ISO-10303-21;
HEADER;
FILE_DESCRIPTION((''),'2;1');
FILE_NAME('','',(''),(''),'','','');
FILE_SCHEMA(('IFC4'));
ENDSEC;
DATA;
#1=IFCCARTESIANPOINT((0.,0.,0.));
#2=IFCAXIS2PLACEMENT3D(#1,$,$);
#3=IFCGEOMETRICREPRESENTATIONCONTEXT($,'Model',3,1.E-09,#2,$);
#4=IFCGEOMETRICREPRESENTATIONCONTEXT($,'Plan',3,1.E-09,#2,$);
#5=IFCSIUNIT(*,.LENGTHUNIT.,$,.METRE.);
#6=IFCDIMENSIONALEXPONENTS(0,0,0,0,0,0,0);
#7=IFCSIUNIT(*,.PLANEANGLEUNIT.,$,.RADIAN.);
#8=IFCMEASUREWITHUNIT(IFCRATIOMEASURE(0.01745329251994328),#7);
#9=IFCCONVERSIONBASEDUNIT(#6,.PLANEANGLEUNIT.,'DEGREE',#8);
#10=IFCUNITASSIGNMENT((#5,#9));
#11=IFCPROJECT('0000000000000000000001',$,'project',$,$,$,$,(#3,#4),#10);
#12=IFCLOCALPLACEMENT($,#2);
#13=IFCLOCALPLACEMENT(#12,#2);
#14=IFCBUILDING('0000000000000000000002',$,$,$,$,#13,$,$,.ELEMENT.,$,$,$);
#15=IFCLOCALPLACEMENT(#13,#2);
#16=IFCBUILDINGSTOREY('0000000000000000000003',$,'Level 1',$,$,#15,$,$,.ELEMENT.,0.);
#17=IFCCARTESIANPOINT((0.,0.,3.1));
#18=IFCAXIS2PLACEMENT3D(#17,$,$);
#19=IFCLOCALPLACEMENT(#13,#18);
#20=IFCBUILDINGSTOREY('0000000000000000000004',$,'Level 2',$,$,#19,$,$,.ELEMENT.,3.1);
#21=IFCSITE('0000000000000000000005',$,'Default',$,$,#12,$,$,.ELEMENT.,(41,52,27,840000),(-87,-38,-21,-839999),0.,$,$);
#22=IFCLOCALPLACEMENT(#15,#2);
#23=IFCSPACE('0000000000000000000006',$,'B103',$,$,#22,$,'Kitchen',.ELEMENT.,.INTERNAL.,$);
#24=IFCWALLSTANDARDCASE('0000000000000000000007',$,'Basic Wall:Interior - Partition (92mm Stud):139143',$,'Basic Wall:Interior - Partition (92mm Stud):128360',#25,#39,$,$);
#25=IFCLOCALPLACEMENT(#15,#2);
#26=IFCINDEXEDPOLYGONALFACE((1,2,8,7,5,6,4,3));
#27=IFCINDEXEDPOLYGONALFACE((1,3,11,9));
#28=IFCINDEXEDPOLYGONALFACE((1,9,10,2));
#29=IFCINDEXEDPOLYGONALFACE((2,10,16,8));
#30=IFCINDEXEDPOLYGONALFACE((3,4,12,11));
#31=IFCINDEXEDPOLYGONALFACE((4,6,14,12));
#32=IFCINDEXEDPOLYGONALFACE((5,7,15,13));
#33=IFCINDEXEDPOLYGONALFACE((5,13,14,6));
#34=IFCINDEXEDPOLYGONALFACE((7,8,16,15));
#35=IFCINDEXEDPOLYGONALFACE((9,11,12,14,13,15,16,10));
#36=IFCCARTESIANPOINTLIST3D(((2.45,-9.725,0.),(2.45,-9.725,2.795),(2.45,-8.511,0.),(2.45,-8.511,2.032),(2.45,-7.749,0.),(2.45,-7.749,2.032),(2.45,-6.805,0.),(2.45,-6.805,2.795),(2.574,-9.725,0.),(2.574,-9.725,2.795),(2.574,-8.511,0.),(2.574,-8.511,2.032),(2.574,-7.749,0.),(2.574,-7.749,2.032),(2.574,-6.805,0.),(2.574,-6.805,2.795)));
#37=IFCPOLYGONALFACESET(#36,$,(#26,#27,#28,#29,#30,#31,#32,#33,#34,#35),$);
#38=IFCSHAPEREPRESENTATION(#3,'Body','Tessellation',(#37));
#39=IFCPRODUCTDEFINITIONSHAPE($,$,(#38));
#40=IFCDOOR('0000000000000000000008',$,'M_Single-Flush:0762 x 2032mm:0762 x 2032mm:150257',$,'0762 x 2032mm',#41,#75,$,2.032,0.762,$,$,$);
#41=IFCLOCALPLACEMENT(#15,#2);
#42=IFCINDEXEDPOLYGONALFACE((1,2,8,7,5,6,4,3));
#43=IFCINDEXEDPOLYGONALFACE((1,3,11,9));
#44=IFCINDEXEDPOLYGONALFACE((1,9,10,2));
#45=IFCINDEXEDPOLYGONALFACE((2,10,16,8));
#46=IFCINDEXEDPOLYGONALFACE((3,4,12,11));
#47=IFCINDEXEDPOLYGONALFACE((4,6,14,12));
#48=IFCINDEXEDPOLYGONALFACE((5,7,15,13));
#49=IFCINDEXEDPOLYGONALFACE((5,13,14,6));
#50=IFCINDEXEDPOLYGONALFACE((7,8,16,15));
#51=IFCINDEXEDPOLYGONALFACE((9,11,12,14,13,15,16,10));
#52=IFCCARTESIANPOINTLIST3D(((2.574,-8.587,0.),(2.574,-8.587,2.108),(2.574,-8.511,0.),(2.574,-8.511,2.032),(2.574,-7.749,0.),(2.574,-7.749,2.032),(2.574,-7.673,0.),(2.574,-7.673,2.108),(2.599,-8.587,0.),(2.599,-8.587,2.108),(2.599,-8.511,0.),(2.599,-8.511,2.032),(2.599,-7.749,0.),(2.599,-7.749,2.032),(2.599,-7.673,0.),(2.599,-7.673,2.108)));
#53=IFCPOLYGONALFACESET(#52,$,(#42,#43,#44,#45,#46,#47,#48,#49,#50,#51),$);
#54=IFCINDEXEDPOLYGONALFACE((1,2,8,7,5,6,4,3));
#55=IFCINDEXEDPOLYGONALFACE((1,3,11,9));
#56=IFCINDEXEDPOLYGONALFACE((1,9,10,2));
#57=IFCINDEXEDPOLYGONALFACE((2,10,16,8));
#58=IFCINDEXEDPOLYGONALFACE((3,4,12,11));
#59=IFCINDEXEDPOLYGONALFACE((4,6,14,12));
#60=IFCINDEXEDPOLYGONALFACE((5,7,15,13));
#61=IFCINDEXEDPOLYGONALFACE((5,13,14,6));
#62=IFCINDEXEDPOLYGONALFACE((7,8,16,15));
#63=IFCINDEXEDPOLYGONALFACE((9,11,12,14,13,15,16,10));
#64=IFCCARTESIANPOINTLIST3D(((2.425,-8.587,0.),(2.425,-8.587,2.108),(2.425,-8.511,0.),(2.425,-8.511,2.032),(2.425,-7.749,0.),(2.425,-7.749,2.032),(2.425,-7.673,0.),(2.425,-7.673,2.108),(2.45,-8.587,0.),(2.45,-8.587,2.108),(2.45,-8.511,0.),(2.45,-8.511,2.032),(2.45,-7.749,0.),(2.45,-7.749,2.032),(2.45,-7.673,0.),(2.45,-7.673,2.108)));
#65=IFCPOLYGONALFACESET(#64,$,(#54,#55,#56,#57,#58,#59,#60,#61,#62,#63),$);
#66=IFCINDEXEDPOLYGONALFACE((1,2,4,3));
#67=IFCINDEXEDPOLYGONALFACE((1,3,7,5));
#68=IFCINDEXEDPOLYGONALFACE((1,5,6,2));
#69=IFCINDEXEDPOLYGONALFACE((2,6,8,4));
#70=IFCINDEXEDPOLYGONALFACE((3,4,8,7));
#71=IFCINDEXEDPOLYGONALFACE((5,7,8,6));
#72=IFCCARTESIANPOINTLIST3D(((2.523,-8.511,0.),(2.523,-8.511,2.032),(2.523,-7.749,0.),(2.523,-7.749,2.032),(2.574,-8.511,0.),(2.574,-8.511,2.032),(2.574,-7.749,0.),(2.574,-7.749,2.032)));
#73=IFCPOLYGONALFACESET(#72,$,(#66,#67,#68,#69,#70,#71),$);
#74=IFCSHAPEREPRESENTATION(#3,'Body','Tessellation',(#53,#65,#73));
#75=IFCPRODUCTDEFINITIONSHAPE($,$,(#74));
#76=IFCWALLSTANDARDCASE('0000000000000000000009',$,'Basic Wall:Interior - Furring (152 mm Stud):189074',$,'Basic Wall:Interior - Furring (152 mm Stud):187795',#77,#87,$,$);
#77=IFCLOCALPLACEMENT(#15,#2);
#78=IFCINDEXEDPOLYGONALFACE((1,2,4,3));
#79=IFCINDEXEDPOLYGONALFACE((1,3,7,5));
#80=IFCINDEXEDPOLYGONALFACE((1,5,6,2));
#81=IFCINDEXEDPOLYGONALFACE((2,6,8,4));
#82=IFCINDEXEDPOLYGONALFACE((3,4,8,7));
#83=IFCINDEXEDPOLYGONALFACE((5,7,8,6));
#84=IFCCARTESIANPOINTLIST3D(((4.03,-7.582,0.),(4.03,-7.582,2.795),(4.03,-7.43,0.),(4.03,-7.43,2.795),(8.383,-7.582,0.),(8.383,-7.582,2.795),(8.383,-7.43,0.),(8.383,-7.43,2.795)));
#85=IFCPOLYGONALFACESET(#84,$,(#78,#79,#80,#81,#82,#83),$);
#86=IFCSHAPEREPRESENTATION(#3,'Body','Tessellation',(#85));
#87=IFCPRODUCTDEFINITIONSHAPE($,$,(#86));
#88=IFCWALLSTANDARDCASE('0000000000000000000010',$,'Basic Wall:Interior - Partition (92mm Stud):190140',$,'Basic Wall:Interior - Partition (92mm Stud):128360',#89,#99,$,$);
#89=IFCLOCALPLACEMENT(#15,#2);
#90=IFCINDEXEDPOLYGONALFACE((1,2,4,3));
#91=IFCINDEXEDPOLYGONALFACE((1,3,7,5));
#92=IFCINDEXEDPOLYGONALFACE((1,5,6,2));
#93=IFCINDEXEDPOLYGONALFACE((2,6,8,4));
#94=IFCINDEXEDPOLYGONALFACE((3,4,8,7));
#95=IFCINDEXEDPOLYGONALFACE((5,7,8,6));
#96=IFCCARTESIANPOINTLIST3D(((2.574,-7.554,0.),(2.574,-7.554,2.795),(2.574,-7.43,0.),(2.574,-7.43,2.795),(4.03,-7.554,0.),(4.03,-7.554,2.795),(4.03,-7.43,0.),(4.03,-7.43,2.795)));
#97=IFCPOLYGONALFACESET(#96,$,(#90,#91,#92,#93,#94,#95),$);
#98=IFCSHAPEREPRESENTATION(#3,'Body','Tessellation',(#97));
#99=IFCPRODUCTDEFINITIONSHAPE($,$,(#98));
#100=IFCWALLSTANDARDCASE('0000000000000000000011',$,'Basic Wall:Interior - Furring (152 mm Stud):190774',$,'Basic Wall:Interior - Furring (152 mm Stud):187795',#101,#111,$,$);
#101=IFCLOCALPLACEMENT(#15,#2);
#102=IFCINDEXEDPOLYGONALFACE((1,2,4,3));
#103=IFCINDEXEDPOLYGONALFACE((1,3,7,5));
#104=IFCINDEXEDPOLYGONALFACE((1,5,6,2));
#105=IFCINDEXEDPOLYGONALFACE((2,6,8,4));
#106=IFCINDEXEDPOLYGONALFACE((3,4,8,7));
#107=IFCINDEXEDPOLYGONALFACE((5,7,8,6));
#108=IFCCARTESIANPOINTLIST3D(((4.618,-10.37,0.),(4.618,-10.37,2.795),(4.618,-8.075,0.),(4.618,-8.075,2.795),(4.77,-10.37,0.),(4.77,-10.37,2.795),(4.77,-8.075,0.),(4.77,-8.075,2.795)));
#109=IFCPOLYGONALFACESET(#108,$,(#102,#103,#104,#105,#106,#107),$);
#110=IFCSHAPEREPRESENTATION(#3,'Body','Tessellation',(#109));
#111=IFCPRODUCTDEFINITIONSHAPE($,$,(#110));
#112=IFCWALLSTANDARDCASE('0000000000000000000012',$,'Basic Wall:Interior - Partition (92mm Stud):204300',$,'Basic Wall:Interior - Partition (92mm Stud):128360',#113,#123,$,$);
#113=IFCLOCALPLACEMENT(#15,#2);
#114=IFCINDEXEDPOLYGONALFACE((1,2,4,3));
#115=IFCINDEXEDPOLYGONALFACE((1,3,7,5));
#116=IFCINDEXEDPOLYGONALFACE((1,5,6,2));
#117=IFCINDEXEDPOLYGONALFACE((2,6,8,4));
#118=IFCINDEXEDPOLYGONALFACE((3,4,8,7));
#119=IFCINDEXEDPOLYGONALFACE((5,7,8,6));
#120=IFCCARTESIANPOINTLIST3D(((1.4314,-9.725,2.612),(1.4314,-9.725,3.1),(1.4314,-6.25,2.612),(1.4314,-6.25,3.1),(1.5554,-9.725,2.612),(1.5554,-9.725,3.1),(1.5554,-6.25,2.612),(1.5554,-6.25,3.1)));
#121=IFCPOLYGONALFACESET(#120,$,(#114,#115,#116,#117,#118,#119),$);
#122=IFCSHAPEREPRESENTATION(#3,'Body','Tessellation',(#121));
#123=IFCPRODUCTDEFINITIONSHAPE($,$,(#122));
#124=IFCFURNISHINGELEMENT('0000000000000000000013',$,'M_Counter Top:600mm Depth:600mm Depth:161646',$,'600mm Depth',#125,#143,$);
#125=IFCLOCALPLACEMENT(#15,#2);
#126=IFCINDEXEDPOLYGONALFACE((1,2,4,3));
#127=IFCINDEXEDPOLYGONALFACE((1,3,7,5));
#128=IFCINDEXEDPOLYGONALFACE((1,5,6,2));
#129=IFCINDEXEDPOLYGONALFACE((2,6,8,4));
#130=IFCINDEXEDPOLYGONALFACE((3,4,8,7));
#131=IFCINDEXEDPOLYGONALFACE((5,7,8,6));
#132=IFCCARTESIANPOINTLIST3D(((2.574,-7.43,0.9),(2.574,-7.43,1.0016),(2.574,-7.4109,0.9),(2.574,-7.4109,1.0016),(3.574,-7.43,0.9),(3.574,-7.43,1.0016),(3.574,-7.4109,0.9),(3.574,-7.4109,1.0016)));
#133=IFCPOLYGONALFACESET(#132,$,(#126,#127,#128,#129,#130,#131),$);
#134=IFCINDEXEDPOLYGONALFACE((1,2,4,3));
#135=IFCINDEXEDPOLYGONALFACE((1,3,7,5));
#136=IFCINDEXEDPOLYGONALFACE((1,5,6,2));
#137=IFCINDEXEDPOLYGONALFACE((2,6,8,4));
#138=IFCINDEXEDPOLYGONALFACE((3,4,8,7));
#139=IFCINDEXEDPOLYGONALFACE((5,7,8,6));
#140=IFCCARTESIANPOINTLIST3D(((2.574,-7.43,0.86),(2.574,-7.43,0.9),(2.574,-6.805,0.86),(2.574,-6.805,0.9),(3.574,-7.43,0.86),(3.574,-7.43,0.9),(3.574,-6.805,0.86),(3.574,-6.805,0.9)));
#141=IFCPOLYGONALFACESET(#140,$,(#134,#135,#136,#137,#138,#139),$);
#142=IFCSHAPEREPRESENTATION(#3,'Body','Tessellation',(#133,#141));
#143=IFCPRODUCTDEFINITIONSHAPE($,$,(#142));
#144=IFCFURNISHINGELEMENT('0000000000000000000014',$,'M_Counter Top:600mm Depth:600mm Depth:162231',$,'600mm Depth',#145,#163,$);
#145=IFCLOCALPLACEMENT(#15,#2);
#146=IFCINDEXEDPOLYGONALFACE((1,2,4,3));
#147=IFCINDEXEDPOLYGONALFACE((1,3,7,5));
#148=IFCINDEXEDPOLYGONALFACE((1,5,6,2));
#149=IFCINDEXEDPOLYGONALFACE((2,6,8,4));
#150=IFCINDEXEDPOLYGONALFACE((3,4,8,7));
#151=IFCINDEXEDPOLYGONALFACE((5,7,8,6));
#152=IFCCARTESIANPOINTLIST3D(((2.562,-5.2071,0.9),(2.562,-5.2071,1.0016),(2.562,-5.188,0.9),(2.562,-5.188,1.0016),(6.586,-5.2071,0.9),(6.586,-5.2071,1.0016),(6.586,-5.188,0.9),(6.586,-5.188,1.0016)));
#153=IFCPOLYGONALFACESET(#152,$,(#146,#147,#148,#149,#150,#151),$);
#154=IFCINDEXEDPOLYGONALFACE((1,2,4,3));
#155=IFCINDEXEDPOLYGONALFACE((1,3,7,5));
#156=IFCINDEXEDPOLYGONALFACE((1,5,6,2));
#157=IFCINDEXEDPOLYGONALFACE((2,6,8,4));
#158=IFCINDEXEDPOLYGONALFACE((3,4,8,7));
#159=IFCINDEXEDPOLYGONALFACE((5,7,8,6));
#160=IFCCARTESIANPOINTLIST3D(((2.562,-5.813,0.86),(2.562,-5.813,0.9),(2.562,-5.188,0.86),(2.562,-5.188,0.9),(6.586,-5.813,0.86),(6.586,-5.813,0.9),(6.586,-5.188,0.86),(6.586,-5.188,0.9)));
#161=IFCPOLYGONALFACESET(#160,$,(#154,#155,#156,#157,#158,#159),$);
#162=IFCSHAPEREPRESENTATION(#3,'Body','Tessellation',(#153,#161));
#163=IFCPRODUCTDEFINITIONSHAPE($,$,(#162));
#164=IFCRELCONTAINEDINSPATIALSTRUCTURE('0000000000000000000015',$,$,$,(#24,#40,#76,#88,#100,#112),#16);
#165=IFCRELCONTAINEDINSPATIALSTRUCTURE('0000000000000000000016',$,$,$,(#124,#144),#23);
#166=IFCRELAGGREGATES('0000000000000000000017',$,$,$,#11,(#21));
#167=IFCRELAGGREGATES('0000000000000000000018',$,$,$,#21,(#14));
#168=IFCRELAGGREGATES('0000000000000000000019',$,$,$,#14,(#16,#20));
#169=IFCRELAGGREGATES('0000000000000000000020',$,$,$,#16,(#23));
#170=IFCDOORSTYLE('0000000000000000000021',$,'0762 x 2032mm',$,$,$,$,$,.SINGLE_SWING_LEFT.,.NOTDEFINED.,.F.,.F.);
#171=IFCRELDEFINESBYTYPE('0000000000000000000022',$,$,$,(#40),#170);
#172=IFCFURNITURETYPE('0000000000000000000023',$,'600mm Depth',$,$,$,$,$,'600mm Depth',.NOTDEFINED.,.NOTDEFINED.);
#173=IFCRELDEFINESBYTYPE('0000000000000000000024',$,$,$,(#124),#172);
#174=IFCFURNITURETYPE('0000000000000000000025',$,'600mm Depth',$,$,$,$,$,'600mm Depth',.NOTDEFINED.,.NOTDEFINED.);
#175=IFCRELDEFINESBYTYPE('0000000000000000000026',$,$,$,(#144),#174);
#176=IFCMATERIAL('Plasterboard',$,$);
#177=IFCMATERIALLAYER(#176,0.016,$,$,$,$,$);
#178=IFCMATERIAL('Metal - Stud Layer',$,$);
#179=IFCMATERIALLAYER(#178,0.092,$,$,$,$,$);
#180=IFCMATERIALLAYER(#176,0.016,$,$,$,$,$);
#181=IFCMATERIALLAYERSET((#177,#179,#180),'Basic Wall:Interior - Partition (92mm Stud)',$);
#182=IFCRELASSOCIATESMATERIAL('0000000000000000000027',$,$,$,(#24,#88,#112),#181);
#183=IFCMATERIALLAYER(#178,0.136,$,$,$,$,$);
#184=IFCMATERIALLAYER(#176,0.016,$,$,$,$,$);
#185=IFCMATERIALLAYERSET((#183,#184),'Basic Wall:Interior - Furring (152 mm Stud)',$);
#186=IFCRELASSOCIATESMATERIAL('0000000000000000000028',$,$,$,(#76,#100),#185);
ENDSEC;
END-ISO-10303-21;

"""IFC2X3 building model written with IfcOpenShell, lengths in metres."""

from ifc_helpers import new_model, entity, si_unit, converted_unit, frame, frame_2d, origin, origin_2d_with_axis, place, context, project, spatial, polyline, rectangle, outline, extrude, clip, bounded_halfspace, source, transform, mapped, material, layer, layer_set, layer_usage, type_object, type_shapes, element, fill, save


model = new_model("IFC2X3")

# Units and contexts
model_context = context("Model", 3, precision=1e-09, world=origin())
plan_context = context("Plan", 3, precision=1e-09, world=origin())
ifc_project = project(units=[si_unit("LENGTHUNIT", "METRE"), converted_unit("PLANEANGLEUNIT", "DEGREE", entity("IfcRatioMeasure", 0.01745329251994328), si_unit("PLANEANGLEUNIT", "RADIAN"), dimensions=[0, 0, 0, 0, 0, 0, 0])], contexts=[model_context, plan_context])

# Site, building, storey
site_placement = place(None, origin())
site = spatial("IfcSite", under=ifc_project, at=site_placement, Name="Default", CompositionType="ELEMENT", RefLatitude=(41, 52, 27, 840000), RefLongitude=(-87, -38, -21, -839999), RefElevation=0.0)
building_placement = place(site_placement, origin())
building = spatial("IfcBuilding", under=site, at=building_placement, CompositionType="ELEMENT")
storey_1_placement = place(building_placement, origin())
storey_1 = spatial("IfcBuildingStorey", under=building, at=storey_1_placement, Name="Level 1", CompositionType="ELEMENT", Elevation=0.0)

# Shared definitions
ifc_material_1 = material(Name="Metal - Stud Layer")
ifc_material_2 = material(Name="Plasterboard")

# Wall, opening, door
ifc_layer_1 = layer(ifc_material_2, 0.016)
ifc_layer_2 = layer(ifc_material_1, 0.092)
ifc_layer_3 = layer(ifc_material_2, 0.016)
ifc_layer_set_1 = layer_set([ifc_layer_1, ifc_layer_2, ifc_layer_3], Name="Basic Wall:Interior - Partition (92mm Stud)")
ifc_layer_usage_1 = layer_usage(ifc_layer_set_1, "AXIS2", "NEGATIVE", 0.062)
wall_1_placement = place(storey_1_placement, frame((2.512, -6.805, 0.0), z_axis=(0.0, 0.0, 1.0), x_axis=(0.0, -1.0, 0.0)))
wall_1 = element("IfcWallStandardCase", 1, at=wall_1_placement, inside=storey_1, material=ifc_layer_usage_1, Name="Basic Wall:Interior - Partition (92mm Stud):139143", ObjectType="Basic Wall:Interior - Partition (92mm Stud):128360", context=model_context, shape_type="SweptSolid", body=[
    extrude(rectangle(XDim=2.92, YDim=0.124, at=frame_2d((1.46, 0.0), x_axis=(-1.0, 0.0))), origin(), (0.0, 0.0, 1.0), 2.795),
])
opening_1_placement = place(wall_1_placement, frame((0.944, -0.062, 0.0)))
opening_1 = element("IfcOpeningElement", 2, at=opening_1_placement, cuts=wall_1, ObjectType="Opening", context=model_context, shape_type="SweptSolid", body=[
    extrude(rectangle(XDim=0.762, YDim=2.032, at=frame_2d((1.016, 0.381), x_axis=(0.0, -1.0))), frame((0.0, 0.0, 0.0), z_axis=(0.0, 1.0, 0.0), x_axis=(0.0, 0.0, 1.0)), (0.0, 0.0, 1.0), 0.124),
])
door_style_1 = type_object("IfcDoorStyle", Name="0762 x 2032mm", ConstructionType="NOTDEFINED", OperationType="SINGLE_SWING_LEFT", ParameterTakesPrecedence=False, Sizeable=False)
shared_shape_1 = source(origin(), model_context, "Body", "SweptSolid", [
    extrude(outline(polyline([(-0.457, -1.073), (0.457, -1.073), (0.457, 1.035), (0.381, 1.035), (0.381, -0.997), (-0.381, -0.997), (-0.381, 1.035), (-0.457, 1.035), (-0.457, -1.073)])), frame((0.381, 0.149, 1.035), z_axis=(0.0, -1.0, 0.0), x_axis=(-1.0, 0.0, 0.0)), (0.0, 0.0, 1.0), 0.025),
    extrude(outline(polyline([(-1.073, -0.457), (1.035, -0.457), (1.035, -0.381), (-0.997, -0.381), (-0.997, 0.381), (1.035, 0.381), (1.035, 0.457), (-1.073, 0.457), (-1.073, -0.457)])), frame((0.381, 0.0, 1.035), z_axis=(0.0, -1.0, 0.0), x_axis=(0.0, 0.0, -1.0)), (0.0, 0.0, 1.0), 0.025),
    extrude(rectangle(XDim=0.762, YDim=0.051, at=origin_2d_with_axis()), frame((0.381, 0.0985, 0.0)), (0.0, 0.0, 1.0), 2.032),
])
type_shapes(door_style_1, [shared_shape_1])
door_1_placement = place(opening_1_placement, origin())
door_1 = element("IfcDoor", 3, at=door_1_placement, inside=storey_1, type_object=door_style_1, Name="M_Single-Flush:0762 x 2032mm:0762 x 2032mm:150257", ObjectType="0762 x 2032mm", OverallHeight=2.032, OverallWidth=0.762, context=model_context, shape_type="MappedRepresentation", body=[
    mapped(shared_shape_1, transform((0.0, 0.0, 0.0), scale=1.0)),
])
fill(opening_1, door_1)

# Shared definitions
storey_2_placement = place(building_placement, frame((0.0, 0.0, 3.1)))
storey_2 = spatial("IfcBuildingStorey", under=building, at=storey_2_placement, Name="Level 2", CompositionType="ELEMENT", Elevation=3.1)

# Walls
ifc_layer_4 = layer(ifc_material_1, 0.136)
ifc_layer_5 = layer(ifc_material_2, 0.016)
ifc_layer_set_2 = layer_set([ifc_layer_4, ifc_layer_5], Name="Basic Wall:Interior - Furring (152 mm Stud)")
ifc_layer_usage_2 = layer_usage(ifc_layer_set_2, "AXIS2", "NEGATIVE", 0.076)
wall_2_placement = place(storey_1_placement, frame((8.383, -7.506, 0.0), z_axis=(0.0, 0.0, 1.0), x_axis=(-1.0, 0.0, 0.0)))
element("IfcWallStandardCase", 4, at=wall_2_placement, inside=storey_1, material=ifc_layer_usage_2, Name="Basic Wall:Interior - Furring (152 mm Stud):189074", ObjectType="Basic Wall:Interior - Furring (152 mm Stud):187795", context=model_context, shape_type="Clipping", body=[
    clip(extrude(rectangle(XDim=4.353, YDim=0.152, at=frame_2d((2.1765, 0.0), x_axis=(-1.0, 0.0))), origin(), (0.0, 0.0, 1.0), 2.795), bounded_halfspace(frame((0.0, -0.076, 2.795), z_axis=(0.0, 0.0, -1.0), x_axis=(0.0, 1.0, 0.0)), True, frame((0.0, -0.076, 2.795)), polyline([(0.0, 0.0), (3.708, 0.0), (3.708, 0.152), (0.0, 0.152), (0.0, 0.0)]))),
])
ifc_layer_usage_3 = layer_usage(ifc_layer_set_1, "AXIS2", "NEGATIVE", 0.062)
wall_3_placement = place(storey_1_placement, frame((4.03, -7.492, 0.0), z_axis=(0.0, 0.0, 1.0), x_axis=(-1.0, 0.0, 0.0)))
element("IfcWallStandardCase", 5, at=wall_3_placement, inside=storey_1, material=ifc_layer_usage_3, Name="Basic Wall:Interior - Partition (92mm Stud):190140", ObjectType="Basic Wall:Interior - Partition (92mm Stud):128360", context=model_context, shape_type="SweptSolid", body=[
    extrude(rectangle(XDim=1.456, YDim=0.124, at=frame_2d((0.728, 0.0), x_axis=(-1.0, 0.0))), origin(), (0.0, 0.0, 1.0), 2.795),
])
ifc_layer_usage_4 = layer_usage(ifc_layer_set_2, "AXIS2", "POSITIVE", -0.076)
wall_4_placement = place(storey_1_placement, frame((4.694, -8.075, 0.0), z_axis=(0.0, 0.0, 1.0), x_axis=(0.0, -1.0, 0.0)))
element("IfcWallStandardCase", 6, at=wall_4_placement, inside=storey_1, material=ifc_layer_usage_4, Name="Basic Wall:Interior - Furring (152 mm Stud):190774", ObjectType="Basic Wall:Interior - Furring (152 mm Stud):187795", context=model_context, shape_type="SweptSolid", body=[
    extrude(rectangle(XDim=2.295, YDim=0.152, at=frame_2d((1.1475, 0.0), x_axis=(-1.0, 0.0))), origin(), (0.0, 0.0, 1.0), 2.795),
])
ifc_layer_usage_5 = layer_usage(ifc_layer_set_1, "AXIS2", "NEGATIVE", 0.062)
wall_5_placement = place(storey_1_placement, frame((1.4934, -6.25, 2.612), z_axis=(0.0, 0.0, 1.0), x_axis=(0.0, -1.0, 0.0)))
element("IfcWallStandardCase", 7, at=wall_5_placement, inside=storey_1, material=ifc_layer_usage_5, Name="Basic Wall:Interior - Partition (92mm Stud):204300", ObjectType="Basic Wall:Interior - Partition (92mm Stud):128360", context=model_context, shape_type="SweptSolid", body=[
    extrude(rectangle(XDim=3.475, YDim=0.124, at=frame_2d((1.7375, 0.0), x_axis=(-1.0, 0.0))), origin(), (0.0, 0.0, 1.0), 0.488),
])

# Shared definitions
space_1_placement = place(storey_1_placement, origin())
space_1 = spatial("IfcSpace", under=storey_1, at=space_1_placement, Name="B103", LongName="Kitchen", CompositionType="ELEMENT", InteriorOrExteriorSpace="INTERNAL")

# Furnishing elements
furniture_type_1 = type_object("IfcFurnitureType", Name="600mm Depth", ElementType="600mm Depth", AssemblyPlace="NOTDEFINED")
shared_shape_2 = source(origin(), model_context, "Body", "SweptSolid", [
    extrude(rectangle(XDim=0.0191, YDim=1.0, at=origin_2d_with_axis()), frame((-0.7005, -0.0095, 0.9), z_axis=(0.0, 0.0, 1.0), x_axis=(0.0, -1.0, 0.0)), (0.0, 0.0, 1.0), 0.1016),
    extrude(rectangle(XDim=1.0, YDim=0.625, at=origin_2d_with_axis()), frame((-0.7005, -0.3125, 0.86), z_axis=(0.0, 0.0, 1.0), x_axis=(-1.0, 0.0, 0.0)), (0.0, 0.0, 1.0), 0.04),
])
type_shapes(furniture_type_1, [shared_shape_2])
furnishing_1_placement = place(space_1_placement, frame((2.3735, -7.43, 0.0), z_axis=(0.0, 0.0, 1.0), x_axis=(-1.0, 0.0, 0.0)))
element("IfcFurnishingElement", 8, at=furnishing_1_placement, inside=space_1, type_object=furniture_type_1, Name="M_Counter Top:600mm Depth:600mm Depth:161646", ObjectType="600mm Depth", context=model_context, shape_type="MappedRepresentation", body=[
    mapped(shared_shape_2, transform((0.0, 0.0, 0.0), scale=1.0)),
])
furniture_type_2 = type_object("IfcFurnitureType", Name="600mm Depth", ElementType="600mm Depth", AssemblyPlace="NOTDEFINED")
shared_shape_3 = source(origin(), model_context, "Body", "SweptSolid", [
    extrude(rectangle(XDim=0.0191, YDim=4.024, at=origin_2d_with_axis()), frame((0.8115, -0.0095, 0.9), z_axis=(0.0, 0.0, 1.0), x_axis=(0.0, -1.0, 0.0)), (0.0, 0.0, 1.0), 0.1016),
    extrude(rectangle(XDim=4.024, YDim=0.625, at=origin_2d_with_axis()), frame((0.8115, -0.3125, 0.86), z_axis=(0.0, 0.0, 1.0), x_axis=(-1.0, 0.0, 0.0)), (0.0, 0.0, 1.0), 0.04),
])
type_shapes(furniture_type_2, [shared_shape_3])
furnishing_2_placement = place(space_1_placement, frame((3.7625, -5.188, 0.0)))
element("IfcFurnishingElement", 9, at=furnishing_2_placement, inside=space_1, type_object=furniture_type_2, Name="M_Counter Top:600mm Depth:600mm Depth:162231", ObjectType="600mm Depth", context=model_context, shape_type="MappedRepresentation", body=[
    mapped(shared_shape_3, transform((0.0, 0.0, 0.0), scale=1.0)),
])

save(model, "model.ifc")
